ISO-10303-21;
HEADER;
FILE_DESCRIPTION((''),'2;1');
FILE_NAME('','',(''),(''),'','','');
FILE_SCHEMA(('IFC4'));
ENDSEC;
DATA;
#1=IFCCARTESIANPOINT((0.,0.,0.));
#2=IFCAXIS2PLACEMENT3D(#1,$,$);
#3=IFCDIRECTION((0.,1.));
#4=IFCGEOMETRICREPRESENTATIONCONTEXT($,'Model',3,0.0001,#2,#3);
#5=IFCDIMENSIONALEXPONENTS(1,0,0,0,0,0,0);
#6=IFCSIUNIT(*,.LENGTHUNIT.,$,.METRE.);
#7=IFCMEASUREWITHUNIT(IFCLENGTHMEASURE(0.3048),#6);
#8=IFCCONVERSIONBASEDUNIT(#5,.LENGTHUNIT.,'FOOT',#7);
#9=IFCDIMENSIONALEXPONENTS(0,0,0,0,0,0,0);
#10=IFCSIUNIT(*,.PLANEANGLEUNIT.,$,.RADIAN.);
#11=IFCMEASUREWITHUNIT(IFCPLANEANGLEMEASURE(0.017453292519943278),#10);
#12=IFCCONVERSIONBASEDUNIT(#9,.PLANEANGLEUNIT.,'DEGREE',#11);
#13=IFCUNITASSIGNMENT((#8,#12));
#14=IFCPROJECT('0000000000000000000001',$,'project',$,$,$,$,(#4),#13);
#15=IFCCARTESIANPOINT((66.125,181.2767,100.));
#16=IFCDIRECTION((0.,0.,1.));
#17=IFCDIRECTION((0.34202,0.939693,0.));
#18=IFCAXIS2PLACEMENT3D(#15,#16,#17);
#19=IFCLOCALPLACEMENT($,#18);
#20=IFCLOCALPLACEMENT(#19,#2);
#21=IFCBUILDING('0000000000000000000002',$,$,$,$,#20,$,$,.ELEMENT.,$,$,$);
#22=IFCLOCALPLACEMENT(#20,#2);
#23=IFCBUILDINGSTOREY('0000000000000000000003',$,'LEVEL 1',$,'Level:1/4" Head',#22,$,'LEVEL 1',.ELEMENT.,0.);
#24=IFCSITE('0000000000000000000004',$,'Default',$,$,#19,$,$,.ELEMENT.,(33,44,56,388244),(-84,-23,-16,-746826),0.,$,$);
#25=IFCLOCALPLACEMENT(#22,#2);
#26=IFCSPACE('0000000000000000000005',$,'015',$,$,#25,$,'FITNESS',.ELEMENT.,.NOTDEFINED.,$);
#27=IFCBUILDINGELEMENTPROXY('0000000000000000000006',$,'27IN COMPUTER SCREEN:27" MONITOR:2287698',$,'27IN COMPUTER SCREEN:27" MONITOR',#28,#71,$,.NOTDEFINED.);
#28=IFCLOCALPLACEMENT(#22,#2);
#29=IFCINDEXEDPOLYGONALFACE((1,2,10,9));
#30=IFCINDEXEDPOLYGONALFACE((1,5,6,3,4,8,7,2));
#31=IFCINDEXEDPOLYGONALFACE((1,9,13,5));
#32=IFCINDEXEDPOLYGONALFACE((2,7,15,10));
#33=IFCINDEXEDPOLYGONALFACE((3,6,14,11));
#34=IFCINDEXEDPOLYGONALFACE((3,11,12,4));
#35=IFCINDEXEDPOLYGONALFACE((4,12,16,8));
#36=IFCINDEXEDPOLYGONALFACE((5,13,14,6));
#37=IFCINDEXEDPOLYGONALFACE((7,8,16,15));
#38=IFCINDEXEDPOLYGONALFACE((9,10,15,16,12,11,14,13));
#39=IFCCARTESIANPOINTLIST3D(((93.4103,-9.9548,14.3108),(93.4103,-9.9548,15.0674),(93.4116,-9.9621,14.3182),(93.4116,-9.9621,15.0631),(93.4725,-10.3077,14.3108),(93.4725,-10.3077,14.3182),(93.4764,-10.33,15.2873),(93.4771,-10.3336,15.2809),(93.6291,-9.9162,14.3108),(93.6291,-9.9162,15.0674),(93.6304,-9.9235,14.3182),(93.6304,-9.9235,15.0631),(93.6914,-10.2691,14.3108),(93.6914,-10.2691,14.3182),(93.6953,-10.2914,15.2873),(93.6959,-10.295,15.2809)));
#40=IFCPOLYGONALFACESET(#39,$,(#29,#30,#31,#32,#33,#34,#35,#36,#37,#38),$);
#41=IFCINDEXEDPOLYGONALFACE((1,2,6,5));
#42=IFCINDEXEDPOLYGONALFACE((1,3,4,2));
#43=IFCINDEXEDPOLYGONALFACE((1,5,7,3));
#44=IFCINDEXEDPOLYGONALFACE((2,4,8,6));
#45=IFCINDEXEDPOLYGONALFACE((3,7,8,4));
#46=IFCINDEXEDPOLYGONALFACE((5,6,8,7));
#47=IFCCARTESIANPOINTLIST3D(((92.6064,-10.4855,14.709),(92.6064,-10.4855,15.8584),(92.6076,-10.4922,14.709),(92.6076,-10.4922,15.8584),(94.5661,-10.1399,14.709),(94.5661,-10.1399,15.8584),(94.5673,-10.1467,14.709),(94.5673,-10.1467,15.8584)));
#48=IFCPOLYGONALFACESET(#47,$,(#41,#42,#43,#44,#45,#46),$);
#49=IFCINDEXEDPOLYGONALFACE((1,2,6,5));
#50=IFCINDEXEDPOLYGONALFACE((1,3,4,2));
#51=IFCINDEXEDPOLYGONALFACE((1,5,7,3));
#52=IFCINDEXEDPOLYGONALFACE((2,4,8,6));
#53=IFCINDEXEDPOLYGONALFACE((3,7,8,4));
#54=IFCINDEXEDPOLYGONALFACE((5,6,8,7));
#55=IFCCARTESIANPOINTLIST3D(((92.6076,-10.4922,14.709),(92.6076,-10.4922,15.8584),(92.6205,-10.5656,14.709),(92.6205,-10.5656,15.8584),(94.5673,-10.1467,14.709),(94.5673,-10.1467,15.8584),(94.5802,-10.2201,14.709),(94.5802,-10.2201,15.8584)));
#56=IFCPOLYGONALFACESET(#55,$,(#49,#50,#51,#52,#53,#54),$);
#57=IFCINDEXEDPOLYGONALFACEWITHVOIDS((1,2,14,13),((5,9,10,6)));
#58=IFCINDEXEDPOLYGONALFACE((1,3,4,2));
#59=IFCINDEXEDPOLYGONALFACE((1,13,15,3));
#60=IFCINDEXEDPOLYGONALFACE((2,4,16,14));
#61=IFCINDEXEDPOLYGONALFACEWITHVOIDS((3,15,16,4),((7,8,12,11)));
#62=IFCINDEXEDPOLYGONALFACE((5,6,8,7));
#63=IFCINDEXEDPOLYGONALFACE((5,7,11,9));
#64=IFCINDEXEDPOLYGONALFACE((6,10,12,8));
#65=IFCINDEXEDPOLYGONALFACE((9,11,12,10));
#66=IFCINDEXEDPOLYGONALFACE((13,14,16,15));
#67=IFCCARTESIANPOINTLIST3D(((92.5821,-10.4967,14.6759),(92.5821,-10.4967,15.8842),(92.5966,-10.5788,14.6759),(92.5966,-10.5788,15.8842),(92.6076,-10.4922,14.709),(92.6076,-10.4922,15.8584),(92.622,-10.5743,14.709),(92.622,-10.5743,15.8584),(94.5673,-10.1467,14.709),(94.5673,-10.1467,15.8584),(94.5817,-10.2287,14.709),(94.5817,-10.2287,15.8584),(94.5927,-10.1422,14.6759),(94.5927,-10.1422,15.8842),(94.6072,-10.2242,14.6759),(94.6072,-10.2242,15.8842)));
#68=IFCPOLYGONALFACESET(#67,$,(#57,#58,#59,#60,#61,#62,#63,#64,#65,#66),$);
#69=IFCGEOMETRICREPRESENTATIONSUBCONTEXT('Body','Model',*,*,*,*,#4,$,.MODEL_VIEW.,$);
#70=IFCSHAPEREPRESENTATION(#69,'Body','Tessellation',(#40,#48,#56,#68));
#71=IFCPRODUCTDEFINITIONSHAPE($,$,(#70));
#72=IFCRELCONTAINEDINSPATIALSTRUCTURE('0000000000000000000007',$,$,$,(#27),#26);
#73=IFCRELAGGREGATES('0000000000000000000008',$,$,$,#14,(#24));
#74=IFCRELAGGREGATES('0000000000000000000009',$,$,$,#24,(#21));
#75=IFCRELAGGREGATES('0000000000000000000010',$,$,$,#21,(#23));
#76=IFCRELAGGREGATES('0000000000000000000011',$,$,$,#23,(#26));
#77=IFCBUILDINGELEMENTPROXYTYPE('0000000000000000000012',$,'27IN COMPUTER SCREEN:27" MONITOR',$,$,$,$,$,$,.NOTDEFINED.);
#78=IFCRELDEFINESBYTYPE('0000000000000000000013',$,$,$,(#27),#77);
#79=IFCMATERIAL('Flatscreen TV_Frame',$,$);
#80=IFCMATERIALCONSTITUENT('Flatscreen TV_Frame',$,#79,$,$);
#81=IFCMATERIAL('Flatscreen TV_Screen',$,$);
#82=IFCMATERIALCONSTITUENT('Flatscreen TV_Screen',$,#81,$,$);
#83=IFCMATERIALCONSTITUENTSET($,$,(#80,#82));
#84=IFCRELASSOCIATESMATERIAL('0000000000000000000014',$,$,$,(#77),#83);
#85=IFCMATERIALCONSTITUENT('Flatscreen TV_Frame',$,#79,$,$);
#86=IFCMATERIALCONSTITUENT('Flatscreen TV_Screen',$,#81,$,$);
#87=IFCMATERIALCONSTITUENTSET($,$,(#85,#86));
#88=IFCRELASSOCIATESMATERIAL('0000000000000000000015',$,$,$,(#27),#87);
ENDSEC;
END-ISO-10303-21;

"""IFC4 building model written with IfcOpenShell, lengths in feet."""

from ifc_helpers import new_model, entity, si_unit, converted_unit, direction, frame, frame_2d, origin, origin_2d_with_axis, place, context, subcontext, project, spatial, polyline, rectangle, outline, extrude, source, transform, mapped, material, constituent, constituent_set, type_object, type_shapes, element, save


model = new_model("IFC4")

# Units and contexts
model_context = context("Model", 3, precision=0.0001, world=origin(), true_north=direction((0.0, 1.0)))
body_context = subcontext(model_context, "Body", "Model", "MODEL_VIEW")
ifc_project = project(units=[converted_unit("LENGTHUNIT", "FOOT", entity("IfcLengthMeasure", 0.3048), si_unit("LENGTHUNIT", "METRE"), dimensions=[1, 0, 0, 0, 0, 0, 0]), converted_unit("PLANEANGLEUNIT", "DEGREE", entity("IfcPlaneAngleMeasure", 0.017453292519943278), si_unit("PLANEANGLEUNIT", "RADIAN"), dimensions=[0, 0, 0, 0, 0, 0, 0])], contexts=[model_context])

# Site, building, storey
site_placement = place(None, frame((66.125, 181.2767, 100.0), z_axis=(0.0, 0.0, 1.0), x_axis=(0.34202, 0.939693, 0.0)))
site = spatial("IfcSite", under=ifc_project, at=site_placement, Name="Default", CompositionType="ELEMENT", RefLatitude=(33, 44, 56, 388244), RefLongitude=(-84, -23, -16, -746826), RefElevation=0.0)
building_placement = place(site_placement, origin())
building = spatial("IfcBuilding", under=site, at=building_placement, CompositionType="ELEMENT")
storey_placement = place(building_placement, origin())
storey = spatial("IfcBuildingStorey", under=building, at=storey_placement, Name="LEVEL 1", ObjectType="Level:1/4\" Head", LongName="LEVEL 1", CompositionType="ELEMENT", Elevation=0.0)

# Shared definitions
space_1_placement = place(storey_placement, origin())
space_1 = spatial("IfcSpace", under=storey, at=space_1_placement, Name="015", LongName="FITNESS", CompositionType="ELEMENT", PredefinedType="NOTDEFINED")

# Shared definitions
ifc_material_1 = material(Name="Flatscreen TV_Frame")
ifc_material_2 = material(Name="Flatscreen TV_Screen")

# Building element proxy
ifc_constituent_1 = constituent(ifc_material_1, Name="Flatscreen TV_Frame")
ifc_constituent_2 = constituent(ifc_material_2, Name="Flatscreen TV_Screen")
ifc_constituent_set_1 = constituent_set(constituents=[ifc_constituent_1, ifc_constituent_2])
building_element_proxy_type_1 = type_object("IfcBuildingElementProxyType", Name="27IN COMPUTER SCREEN:27\" MONITOR", PredefinedType="NOTDEFINED", material=ifc_constituent_set_1)
shared_shape_1 = source(origin(), body_context, "Body", "SweptSolid", [
    extrude(outline(polyline([(0.3657, -0.4392), (0.3731, -0.4392), (0.3731, 0.0007), (-0.2821, 0.379), (-0.4613, 0.0686), (-0.4548, 0.0649), (-0.2794, 0.3688), (0.3657, -0.0036), (0.3657, -0.4392)])), frame((-0.1111, 0.0264, 0.0687), z_axis=(1.0, 0.0, 0.0), x_axis=(0.0, -0.5, 0.866025)), (0.0, 0.0, 1.0), 0.2222),
    extrude(rectangle(XDim=1.9899, YDim=0.0068, at=origin_2d_with_axis()), frame((0.0, 0.2257, 0.0331), z_axis=(0.0, 0.0, 1.0), x_axis=(-1.0, 0.0, 0.0)), (0.0, 0.0, 1.0), 1.1493),
    extrude(rectangle(XDim=1.9899, YDim=0.0746, at=frame_2d((0.0, 0.0), x_axis=(1.0, 0.0))), frame((0.0, 0.2664, 0.0331), z_axis=(0.0, 0.0, 1.0), x_axis=(-1.0, 0.0, 0.0)), (0.0, 0.0, 1.0), 1.1493),
    extrude(outline(polyline([(-0.6042, -1.0208), (0.6042, -1.0208), (0.6042, 1.0208), (-0.6042, 1.0208), (-0.6042, -1.0208)]), holes=[polyline([(-0.5783, -0.995), (-0.5783, 0.995), (0.571, 0.995), (0.571, -0.995), (-0.5783, -0.995)])]), frame((0.0, 0.2292, 0.6042), z_axis=(0.0, 1.0, 0.0), x_axis=(0.0, 0.0, -1.0)), (0.0, 0.0, 1.0), 0.0833),
])
type_shapes(building_element_proxy_type_1, [shared_shape_1])
ifc_constituent_3 = constituent(ifc_material_1, Name="Flatscreen TV_Frame")
ifc_constituent_4 = constituent(ifc_material_2, Name="Flatscreen TV_Screen")
ifc_constituent_set_2 = constituent_set(constituents=[ifc_constituent_3, ifc_constituent_4])
proxy_1_placement = place(space_1_placement, frame((93.5476, -10.0938, 14.6759), z_axis=(0.0, 0.0, 1.0), x_axis=(-0.984808, -0.173648, 0.0)))
element("IfcBuildingElementProxy", 1, at=proxy_1_placement, inside=space_1, type_object=building_element_proxy_type_1, material=ifc_constituent_set_2, Name="27IN COMPUTER SCREEN:27\" MONITOR:2287698", ObjectType="27IN COMPUTER SCREEN:27\" MONITOR", PredefinedType="NOTDEFINED", context=body_context, shape_type="MappedRepresentation", body=[
    mapped(shared_shape_1, transform((0.0, 0.0, 0.0), scale=1.0)),
])

save(model, "model.ifc")
